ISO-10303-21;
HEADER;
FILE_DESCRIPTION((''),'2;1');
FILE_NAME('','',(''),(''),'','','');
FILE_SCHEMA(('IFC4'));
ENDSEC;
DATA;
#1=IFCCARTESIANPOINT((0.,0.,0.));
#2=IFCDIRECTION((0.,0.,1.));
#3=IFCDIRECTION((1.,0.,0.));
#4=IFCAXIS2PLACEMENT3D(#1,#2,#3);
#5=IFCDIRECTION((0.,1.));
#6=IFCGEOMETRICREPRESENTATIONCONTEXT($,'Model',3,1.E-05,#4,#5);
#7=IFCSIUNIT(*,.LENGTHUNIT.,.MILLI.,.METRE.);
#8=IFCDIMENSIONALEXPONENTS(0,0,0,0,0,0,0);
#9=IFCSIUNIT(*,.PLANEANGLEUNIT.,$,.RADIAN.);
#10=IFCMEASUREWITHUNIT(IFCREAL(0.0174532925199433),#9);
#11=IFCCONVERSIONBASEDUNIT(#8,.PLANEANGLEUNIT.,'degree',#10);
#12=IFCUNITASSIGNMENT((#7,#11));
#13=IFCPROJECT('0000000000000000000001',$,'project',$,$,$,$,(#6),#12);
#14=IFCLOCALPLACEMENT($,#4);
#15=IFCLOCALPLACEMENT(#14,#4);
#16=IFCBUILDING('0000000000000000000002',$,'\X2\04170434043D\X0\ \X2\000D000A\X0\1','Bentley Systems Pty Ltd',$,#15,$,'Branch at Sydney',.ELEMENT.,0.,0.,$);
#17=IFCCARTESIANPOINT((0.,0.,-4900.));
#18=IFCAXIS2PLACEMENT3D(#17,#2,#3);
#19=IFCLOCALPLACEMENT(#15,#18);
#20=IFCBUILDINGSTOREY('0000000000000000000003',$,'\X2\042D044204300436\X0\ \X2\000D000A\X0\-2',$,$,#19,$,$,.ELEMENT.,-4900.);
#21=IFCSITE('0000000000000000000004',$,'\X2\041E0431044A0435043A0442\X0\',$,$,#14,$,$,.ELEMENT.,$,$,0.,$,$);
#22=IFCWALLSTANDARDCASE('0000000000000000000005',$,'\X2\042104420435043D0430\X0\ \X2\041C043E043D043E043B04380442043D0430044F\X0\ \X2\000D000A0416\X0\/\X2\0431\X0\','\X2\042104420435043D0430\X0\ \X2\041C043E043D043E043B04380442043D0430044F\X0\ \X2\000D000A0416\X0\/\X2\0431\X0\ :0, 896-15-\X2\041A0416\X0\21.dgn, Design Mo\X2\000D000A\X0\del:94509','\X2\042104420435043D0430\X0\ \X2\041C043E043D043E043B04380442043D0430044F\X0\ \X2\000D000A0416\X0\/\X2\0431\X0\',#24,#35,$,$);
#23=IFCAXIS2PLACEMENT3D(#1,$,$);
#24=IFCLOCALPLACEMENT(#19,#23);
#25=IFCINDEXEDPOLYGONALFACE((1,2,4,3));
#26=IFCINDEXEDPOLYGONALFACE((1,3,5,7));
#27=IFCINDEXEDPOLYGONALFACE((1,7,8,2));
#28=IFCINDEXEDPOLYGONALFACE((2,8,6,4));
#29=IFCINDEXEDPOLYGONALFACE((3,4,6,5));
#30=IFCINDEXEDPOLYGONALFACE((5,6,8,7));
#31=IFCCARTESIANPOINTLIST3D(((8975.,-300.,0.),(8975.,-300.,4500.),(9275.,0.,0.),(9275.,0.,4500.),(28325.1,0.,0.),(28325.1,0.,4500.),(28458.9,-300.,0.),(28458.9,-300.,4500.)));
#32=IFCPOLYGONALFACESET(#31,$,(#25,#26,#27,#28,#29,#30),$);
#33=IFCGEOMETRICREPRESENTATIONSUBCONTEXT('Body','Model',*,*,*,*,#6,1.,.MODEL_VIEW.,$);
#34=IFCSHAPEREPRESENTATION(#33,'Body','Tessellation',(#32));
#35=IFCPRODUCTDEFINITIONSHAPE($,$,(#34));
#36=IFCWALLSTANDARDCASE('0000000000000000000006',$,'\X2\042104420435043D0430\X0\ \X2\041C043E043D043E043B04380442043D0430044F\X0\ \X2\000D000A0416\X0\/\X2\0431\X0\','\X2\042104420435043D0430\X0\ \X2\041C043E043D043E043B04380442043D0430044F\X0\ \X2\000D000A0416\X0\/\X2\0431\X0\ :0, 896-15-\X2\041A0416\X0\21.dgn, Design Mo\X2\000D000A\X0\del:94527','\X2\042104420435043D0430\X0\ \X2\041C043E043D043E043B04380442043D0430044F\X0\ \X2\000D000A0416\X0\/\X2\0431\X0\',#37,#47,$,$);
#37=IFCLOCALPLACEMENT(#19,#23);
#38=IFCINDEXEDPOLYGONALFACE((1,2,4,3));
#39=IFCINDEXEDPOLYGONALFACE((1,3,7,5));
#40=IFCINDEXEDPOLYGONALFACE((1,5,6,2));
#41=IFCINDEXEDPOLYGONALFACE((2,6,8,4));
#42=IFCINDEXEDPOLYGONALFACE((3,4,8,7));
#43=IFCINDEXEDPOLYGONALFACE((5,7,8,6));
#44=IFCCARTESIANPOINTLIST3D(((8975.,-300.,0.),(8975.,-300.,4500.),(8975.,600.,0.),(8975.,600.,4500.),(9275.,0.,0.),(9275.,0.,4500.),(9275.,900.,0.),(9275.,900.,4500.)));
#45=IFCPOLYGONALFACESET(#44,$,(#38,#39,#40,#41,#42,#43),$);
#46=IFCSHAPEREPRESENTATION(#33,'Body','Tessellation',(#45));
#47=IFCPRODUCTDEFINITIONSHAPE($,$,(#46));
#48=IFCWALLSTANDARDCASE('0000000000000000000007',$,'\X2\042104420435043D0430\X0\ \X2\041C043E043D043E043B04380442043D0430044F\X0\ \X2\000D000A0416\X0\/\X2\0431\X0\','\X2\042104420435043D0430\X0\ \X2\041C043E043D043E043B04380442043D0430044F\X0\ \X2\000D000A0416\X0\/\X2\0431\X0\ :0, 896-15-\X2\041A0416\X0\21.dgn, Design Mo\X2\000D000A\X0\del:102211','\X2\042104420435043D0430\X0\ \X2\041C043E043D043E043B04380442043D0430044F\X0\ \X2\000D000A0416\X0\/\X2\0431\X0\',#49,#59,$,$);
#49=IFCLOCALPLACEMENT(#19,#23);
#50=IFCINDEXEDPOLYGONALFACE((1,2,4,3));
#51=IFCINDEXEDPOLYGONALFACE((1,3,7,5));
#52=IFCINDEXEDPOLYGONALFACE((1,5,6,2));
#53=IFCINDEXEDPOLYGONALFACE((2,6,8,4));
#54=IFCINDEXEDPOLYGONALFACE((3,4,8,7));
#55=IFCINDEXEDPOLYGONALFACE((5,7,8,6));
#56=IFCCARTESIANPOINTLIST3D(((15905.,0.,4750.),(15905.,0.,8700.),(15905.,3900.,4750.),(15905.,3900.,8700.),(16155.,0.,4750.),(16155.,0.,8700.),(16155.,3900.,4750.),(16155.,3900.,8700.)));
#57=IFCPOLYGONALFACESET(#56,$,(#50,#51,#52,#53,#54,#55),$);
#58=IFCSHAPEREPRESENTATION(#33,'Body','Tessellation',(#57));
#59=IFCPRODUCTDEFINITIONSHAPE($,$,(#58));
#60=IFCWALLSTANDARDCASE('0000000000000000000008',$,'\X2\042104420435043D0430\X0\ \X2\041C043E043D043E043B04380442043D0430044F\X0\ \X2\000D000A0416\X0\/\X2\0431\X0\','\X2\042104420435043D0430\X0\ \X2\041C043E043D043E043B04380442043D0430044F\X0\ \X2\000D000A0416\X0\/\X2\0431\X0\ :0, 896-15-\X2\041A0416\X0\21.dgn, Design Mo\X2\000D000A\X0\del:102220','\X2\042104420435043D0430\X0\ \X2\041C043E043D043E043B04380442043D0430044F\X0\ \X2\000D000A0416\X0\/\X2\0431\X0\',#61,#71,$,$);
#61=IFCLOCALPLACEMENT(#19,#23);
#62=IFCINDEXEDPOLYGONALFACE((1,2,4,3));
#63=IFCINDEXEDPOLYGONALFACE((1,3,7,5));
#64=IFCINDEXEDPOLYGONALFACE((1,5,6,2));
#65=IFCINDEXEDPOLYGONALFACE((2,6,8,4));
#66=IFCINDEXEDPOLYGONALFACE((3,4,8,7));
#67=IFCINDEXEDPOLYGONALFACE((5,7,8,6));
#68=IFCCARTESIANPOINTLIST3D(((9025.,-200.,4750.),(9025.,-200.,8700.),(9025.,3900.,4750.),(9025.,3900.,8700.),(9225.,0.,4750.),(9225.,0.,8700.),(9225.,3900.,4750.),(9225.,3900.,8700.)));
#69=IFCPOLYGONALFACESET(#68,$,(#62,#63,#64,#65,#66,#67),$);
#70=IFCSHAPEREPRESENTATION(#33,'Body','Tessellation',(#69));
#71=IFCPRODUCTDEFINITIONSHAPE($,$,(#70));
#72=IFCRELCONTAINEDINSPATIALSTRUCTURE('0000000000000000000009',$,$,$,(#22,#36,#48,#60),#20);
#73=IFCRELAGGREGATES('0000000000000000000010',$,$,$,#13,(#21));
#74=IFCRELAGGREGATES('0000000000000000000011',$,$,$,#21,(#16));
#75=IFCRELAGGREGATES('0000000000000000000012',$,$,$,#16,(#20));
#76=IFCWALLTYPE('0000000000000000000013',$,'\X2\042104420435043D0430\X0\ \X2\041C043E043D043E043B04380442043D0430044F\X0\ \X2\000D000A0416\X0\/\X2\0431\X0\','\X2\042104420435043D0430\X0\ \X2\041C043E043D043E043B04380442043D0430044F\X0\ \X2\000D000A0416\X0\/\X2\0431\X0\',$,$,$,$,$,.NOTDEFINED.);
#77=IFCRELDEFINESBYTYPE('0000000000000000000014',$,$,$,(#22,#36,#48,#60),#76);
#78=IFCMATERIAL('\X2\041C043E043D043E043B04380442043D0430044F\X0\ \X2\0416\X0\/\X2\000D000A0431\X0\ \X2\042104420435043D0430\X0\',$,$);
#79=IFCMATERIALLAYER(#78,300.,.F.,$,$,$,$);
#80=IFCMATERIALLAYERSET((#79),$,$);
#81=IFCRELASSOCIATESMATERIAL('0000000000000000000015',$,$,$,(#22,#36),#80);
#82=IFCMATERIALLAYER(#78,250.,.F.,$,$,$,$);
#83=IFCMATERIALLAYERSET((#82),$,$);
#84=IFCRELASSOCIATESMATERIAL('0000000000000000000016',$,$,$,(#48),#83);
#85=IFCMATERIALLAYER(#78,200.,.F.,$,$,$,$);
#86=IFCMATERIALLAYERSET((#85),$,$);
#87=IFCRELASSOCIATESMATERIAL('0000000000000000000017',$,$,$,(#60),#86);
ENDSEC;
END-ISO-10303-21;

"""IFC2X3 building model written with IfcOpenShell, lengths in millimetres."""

from ifc_helpers import new_model, entity, si_unit, converted_unit, direction, frame, frame_2d, origin_with_axes, place, context, subcontext, project, spatial, polyline, rectangle, outline, extrude, material, layer, layer_set, layer_usage, type_object, element, save


model = new_model("IFC2X3")

# Units and contexts
model_context = context("Model", 3, precision=1e-05, world=origin_with_axes(), true_north=direction((0.0, 1.0)))
body_context = subcontext(model_context, "Body", "Model", "MODEL_VIEW", scale=1.0)
ifc_project = project(units=[si_unit("LENGTHUNIT", "METRE", prefix="MILLI"), converted_unit("PLANEANGLEUNIT", "degree", entity("IfcReal", 0.0174532925199433), si_unit("PLANEANGLEUNIT", "RADIAN"), dimensions=[0, 0, 0, 0, 0, 0, 0])], contexts=[model_context])

# Site, building, storey
site_placement = place(None, origin_with_axes())
site = spatial("IfcSite", under=ifc_project, at=site_placement, Name="Объект", CompositionType="ELEMENT", RefElevation=0.0)
building_placement = place(site_placement, origin_with_axes())
building = spatial("IfcBuilding", under=site, at=building_placement, Name="Здн \r\n1", Description="Bentley Systems Pty Ltd", LongName="Branch at Sydney", CompositionType="ELEMENT", ElevationOfRefHeight=0.0, ElevationOfTerrain=0.0)
storey_placement = place(building_placement, frame((0.0, 0.0, -4900.0), z_axis=(0.0, 0.0, 1.0), x_axis=(1.0, 0.0, 0.0)))
storey = spatial("IfcBuildingStorey", under=building, at=storey_placement, Name="Этаж \r\n-2", CompositionType="ELEMENT", Elevation=-4900.0)

# Walls
ifc_material = material(Name="Монолитная Ж/\r\nб Стена")
ifc_layer_1 = layer(ifc_material, 300.0, ventilated=False)
ifc_layer_set_1 = layer_set([ifc_layer_1])
ifc_layer_usage_1 = layer_usage(ifc_layer_set_1, "AXIS2", "POSITIVE", 0.0)
wall_type = type_object("IfcWallType", Name="Стена Монолитная \r\nЖ/б", Description="Стена Монолитная \r\nЖ/б", PredefinedType="NOTDEFINED")
wall_1_placement = place(storey_placement, frame((8975.0, -300.0, 0.0), z_axis=(0.0, 0.0, 1.0), x_axis=(1.0, 0.0, 0.0)))
element("IfcWallStandardCase", 1, at=wall_1_placement, inside=storey, type_object=wall_type, material=ifc_layer_usage_1, Name="Стена Монолитная \r\nЖ/б", Description="Стена Монолитная \r\nЖ/б :0, 896-15-КЖ21.dgn, Design Mo\r\ndel:94509", ObjectType="Стена Монолитная \r\nЖ/б", context=body_context, shape_type="SweptSolid", body=[
    extrude(outline(polyline([(19350.1, 300.0), (300.0, 300.0), (0.0, 0.0), (19483.9, 0.0), (19350.1, 300.0)])), origin_with_axes(), (0.0, 0.0, 1.0), 4500.0),
])
wall_2_placement = place(storey_placement, frame((8975.0, 600.0, 0.0), z_axis=(0.0, 0.0, 1.0), x_axis=(0.0, -1.0, 0.0)))
element("IfcWallStandardCase", 2, at=wall_2_placement, inside=storey, type_object=wall_type, material=ifc_layer_usage_1, Name="Стена Монолитная \r\nЖ/б", Description="Стена Монолитная \r\nЖ/б :0, 896-15-КЖ21.dgn, Design Mo\r\ndel:94527", ObjectType="Стена Монолитная \r\nЖ/б", context=body_context, shape_type="SweptSolid", body=[
    extrude(outline(polyline([(600.0, 300.0), (-300.0, 300.0), (0.0, 0.0), (900.0, 0.0), (600.0, 300.0)])), origin_with_axes(), (0.0, 0.0, 1.0), 4500.0),
])
ifc_layer_2 = layer(ifc_material, 250.0, ventilated=False)
ifc_layer_set_2 = layer_set([ifc_layer_2])
ifc_layer_usage_2 = layer_usage(ifc_layer_set_2, "AXIS2", "POSITIVE", 0.0)
wall_3_placement = place(storey_placement, frame((15905.0, 0.0, 4750.0), z_axis=(0.0, 0.0, 1.0), x_axis=(0.0, 1.0, 0.0)))
element("IfcWallStandardCase", 3, at=wall_3_placement, inside=storey, type_object=wall_type, material=ifc_layer_usage_2, Name="Стена Монолитная \r\nЖ/б", Description="Стена Монолитная \r\nЖ/б :0, 896-15-КЖ21.dgn, Design Mo\r\ndel:102211", ObjectType="Стена Монолитная \r\nЖ/б", context=body_context, shape_type="SweptSolid", body=[
    extrude(rectangle(XDim=3900.0, YDim=250.0, at=frame_2d((1950.0, -125.0), x_axis=(1.0, 0.0))), origin_with_axes(), (0.0, 0.0, 1.0), 3950.0),
])
ifc_layer_3 = layer(ifc_material, 200.0, ventilated=False)
ifc_layer_set_3 = layer_set([ifc_layer_3])
ifc_layer_usage_3 = layer_usage(ifc_layer_set_3, "AXIS2", "POSITIVE", 0.0)
wall_4_placement = place(storey_placement, frame((9025.0, -200.0, 4750.0), z_axis=(0.0, 0.0, 1.0), x_axis=(0.0, 1.0, 0.0)))
element("IfcWallStandardCase", 4, at=wall_4_placement, inside=storey, type_object=wall_type, material=ifc_layer_usage_3, Name="Стена Монолитная \r\nЖ/б", Description="Стена Монолитная \r\nЖ/б :0, 896-15-КЖ21.dgn, Design Mo\r\ndel:102220", ObjectType="Стена Монолитная \r\nЖ/б", context=body_context, shape_type="SweptSolid", body=[
    extrude(outline(polyline([(0.0, 0.0), (200.0, -200.0), (4100.0, -200.0), (4100.0, 0.0), (0.0, 0.0)])), origin_with_axes(), (0.0, 0.0, 1.0), 3950.0),
])

save(model, "model.ifc")
